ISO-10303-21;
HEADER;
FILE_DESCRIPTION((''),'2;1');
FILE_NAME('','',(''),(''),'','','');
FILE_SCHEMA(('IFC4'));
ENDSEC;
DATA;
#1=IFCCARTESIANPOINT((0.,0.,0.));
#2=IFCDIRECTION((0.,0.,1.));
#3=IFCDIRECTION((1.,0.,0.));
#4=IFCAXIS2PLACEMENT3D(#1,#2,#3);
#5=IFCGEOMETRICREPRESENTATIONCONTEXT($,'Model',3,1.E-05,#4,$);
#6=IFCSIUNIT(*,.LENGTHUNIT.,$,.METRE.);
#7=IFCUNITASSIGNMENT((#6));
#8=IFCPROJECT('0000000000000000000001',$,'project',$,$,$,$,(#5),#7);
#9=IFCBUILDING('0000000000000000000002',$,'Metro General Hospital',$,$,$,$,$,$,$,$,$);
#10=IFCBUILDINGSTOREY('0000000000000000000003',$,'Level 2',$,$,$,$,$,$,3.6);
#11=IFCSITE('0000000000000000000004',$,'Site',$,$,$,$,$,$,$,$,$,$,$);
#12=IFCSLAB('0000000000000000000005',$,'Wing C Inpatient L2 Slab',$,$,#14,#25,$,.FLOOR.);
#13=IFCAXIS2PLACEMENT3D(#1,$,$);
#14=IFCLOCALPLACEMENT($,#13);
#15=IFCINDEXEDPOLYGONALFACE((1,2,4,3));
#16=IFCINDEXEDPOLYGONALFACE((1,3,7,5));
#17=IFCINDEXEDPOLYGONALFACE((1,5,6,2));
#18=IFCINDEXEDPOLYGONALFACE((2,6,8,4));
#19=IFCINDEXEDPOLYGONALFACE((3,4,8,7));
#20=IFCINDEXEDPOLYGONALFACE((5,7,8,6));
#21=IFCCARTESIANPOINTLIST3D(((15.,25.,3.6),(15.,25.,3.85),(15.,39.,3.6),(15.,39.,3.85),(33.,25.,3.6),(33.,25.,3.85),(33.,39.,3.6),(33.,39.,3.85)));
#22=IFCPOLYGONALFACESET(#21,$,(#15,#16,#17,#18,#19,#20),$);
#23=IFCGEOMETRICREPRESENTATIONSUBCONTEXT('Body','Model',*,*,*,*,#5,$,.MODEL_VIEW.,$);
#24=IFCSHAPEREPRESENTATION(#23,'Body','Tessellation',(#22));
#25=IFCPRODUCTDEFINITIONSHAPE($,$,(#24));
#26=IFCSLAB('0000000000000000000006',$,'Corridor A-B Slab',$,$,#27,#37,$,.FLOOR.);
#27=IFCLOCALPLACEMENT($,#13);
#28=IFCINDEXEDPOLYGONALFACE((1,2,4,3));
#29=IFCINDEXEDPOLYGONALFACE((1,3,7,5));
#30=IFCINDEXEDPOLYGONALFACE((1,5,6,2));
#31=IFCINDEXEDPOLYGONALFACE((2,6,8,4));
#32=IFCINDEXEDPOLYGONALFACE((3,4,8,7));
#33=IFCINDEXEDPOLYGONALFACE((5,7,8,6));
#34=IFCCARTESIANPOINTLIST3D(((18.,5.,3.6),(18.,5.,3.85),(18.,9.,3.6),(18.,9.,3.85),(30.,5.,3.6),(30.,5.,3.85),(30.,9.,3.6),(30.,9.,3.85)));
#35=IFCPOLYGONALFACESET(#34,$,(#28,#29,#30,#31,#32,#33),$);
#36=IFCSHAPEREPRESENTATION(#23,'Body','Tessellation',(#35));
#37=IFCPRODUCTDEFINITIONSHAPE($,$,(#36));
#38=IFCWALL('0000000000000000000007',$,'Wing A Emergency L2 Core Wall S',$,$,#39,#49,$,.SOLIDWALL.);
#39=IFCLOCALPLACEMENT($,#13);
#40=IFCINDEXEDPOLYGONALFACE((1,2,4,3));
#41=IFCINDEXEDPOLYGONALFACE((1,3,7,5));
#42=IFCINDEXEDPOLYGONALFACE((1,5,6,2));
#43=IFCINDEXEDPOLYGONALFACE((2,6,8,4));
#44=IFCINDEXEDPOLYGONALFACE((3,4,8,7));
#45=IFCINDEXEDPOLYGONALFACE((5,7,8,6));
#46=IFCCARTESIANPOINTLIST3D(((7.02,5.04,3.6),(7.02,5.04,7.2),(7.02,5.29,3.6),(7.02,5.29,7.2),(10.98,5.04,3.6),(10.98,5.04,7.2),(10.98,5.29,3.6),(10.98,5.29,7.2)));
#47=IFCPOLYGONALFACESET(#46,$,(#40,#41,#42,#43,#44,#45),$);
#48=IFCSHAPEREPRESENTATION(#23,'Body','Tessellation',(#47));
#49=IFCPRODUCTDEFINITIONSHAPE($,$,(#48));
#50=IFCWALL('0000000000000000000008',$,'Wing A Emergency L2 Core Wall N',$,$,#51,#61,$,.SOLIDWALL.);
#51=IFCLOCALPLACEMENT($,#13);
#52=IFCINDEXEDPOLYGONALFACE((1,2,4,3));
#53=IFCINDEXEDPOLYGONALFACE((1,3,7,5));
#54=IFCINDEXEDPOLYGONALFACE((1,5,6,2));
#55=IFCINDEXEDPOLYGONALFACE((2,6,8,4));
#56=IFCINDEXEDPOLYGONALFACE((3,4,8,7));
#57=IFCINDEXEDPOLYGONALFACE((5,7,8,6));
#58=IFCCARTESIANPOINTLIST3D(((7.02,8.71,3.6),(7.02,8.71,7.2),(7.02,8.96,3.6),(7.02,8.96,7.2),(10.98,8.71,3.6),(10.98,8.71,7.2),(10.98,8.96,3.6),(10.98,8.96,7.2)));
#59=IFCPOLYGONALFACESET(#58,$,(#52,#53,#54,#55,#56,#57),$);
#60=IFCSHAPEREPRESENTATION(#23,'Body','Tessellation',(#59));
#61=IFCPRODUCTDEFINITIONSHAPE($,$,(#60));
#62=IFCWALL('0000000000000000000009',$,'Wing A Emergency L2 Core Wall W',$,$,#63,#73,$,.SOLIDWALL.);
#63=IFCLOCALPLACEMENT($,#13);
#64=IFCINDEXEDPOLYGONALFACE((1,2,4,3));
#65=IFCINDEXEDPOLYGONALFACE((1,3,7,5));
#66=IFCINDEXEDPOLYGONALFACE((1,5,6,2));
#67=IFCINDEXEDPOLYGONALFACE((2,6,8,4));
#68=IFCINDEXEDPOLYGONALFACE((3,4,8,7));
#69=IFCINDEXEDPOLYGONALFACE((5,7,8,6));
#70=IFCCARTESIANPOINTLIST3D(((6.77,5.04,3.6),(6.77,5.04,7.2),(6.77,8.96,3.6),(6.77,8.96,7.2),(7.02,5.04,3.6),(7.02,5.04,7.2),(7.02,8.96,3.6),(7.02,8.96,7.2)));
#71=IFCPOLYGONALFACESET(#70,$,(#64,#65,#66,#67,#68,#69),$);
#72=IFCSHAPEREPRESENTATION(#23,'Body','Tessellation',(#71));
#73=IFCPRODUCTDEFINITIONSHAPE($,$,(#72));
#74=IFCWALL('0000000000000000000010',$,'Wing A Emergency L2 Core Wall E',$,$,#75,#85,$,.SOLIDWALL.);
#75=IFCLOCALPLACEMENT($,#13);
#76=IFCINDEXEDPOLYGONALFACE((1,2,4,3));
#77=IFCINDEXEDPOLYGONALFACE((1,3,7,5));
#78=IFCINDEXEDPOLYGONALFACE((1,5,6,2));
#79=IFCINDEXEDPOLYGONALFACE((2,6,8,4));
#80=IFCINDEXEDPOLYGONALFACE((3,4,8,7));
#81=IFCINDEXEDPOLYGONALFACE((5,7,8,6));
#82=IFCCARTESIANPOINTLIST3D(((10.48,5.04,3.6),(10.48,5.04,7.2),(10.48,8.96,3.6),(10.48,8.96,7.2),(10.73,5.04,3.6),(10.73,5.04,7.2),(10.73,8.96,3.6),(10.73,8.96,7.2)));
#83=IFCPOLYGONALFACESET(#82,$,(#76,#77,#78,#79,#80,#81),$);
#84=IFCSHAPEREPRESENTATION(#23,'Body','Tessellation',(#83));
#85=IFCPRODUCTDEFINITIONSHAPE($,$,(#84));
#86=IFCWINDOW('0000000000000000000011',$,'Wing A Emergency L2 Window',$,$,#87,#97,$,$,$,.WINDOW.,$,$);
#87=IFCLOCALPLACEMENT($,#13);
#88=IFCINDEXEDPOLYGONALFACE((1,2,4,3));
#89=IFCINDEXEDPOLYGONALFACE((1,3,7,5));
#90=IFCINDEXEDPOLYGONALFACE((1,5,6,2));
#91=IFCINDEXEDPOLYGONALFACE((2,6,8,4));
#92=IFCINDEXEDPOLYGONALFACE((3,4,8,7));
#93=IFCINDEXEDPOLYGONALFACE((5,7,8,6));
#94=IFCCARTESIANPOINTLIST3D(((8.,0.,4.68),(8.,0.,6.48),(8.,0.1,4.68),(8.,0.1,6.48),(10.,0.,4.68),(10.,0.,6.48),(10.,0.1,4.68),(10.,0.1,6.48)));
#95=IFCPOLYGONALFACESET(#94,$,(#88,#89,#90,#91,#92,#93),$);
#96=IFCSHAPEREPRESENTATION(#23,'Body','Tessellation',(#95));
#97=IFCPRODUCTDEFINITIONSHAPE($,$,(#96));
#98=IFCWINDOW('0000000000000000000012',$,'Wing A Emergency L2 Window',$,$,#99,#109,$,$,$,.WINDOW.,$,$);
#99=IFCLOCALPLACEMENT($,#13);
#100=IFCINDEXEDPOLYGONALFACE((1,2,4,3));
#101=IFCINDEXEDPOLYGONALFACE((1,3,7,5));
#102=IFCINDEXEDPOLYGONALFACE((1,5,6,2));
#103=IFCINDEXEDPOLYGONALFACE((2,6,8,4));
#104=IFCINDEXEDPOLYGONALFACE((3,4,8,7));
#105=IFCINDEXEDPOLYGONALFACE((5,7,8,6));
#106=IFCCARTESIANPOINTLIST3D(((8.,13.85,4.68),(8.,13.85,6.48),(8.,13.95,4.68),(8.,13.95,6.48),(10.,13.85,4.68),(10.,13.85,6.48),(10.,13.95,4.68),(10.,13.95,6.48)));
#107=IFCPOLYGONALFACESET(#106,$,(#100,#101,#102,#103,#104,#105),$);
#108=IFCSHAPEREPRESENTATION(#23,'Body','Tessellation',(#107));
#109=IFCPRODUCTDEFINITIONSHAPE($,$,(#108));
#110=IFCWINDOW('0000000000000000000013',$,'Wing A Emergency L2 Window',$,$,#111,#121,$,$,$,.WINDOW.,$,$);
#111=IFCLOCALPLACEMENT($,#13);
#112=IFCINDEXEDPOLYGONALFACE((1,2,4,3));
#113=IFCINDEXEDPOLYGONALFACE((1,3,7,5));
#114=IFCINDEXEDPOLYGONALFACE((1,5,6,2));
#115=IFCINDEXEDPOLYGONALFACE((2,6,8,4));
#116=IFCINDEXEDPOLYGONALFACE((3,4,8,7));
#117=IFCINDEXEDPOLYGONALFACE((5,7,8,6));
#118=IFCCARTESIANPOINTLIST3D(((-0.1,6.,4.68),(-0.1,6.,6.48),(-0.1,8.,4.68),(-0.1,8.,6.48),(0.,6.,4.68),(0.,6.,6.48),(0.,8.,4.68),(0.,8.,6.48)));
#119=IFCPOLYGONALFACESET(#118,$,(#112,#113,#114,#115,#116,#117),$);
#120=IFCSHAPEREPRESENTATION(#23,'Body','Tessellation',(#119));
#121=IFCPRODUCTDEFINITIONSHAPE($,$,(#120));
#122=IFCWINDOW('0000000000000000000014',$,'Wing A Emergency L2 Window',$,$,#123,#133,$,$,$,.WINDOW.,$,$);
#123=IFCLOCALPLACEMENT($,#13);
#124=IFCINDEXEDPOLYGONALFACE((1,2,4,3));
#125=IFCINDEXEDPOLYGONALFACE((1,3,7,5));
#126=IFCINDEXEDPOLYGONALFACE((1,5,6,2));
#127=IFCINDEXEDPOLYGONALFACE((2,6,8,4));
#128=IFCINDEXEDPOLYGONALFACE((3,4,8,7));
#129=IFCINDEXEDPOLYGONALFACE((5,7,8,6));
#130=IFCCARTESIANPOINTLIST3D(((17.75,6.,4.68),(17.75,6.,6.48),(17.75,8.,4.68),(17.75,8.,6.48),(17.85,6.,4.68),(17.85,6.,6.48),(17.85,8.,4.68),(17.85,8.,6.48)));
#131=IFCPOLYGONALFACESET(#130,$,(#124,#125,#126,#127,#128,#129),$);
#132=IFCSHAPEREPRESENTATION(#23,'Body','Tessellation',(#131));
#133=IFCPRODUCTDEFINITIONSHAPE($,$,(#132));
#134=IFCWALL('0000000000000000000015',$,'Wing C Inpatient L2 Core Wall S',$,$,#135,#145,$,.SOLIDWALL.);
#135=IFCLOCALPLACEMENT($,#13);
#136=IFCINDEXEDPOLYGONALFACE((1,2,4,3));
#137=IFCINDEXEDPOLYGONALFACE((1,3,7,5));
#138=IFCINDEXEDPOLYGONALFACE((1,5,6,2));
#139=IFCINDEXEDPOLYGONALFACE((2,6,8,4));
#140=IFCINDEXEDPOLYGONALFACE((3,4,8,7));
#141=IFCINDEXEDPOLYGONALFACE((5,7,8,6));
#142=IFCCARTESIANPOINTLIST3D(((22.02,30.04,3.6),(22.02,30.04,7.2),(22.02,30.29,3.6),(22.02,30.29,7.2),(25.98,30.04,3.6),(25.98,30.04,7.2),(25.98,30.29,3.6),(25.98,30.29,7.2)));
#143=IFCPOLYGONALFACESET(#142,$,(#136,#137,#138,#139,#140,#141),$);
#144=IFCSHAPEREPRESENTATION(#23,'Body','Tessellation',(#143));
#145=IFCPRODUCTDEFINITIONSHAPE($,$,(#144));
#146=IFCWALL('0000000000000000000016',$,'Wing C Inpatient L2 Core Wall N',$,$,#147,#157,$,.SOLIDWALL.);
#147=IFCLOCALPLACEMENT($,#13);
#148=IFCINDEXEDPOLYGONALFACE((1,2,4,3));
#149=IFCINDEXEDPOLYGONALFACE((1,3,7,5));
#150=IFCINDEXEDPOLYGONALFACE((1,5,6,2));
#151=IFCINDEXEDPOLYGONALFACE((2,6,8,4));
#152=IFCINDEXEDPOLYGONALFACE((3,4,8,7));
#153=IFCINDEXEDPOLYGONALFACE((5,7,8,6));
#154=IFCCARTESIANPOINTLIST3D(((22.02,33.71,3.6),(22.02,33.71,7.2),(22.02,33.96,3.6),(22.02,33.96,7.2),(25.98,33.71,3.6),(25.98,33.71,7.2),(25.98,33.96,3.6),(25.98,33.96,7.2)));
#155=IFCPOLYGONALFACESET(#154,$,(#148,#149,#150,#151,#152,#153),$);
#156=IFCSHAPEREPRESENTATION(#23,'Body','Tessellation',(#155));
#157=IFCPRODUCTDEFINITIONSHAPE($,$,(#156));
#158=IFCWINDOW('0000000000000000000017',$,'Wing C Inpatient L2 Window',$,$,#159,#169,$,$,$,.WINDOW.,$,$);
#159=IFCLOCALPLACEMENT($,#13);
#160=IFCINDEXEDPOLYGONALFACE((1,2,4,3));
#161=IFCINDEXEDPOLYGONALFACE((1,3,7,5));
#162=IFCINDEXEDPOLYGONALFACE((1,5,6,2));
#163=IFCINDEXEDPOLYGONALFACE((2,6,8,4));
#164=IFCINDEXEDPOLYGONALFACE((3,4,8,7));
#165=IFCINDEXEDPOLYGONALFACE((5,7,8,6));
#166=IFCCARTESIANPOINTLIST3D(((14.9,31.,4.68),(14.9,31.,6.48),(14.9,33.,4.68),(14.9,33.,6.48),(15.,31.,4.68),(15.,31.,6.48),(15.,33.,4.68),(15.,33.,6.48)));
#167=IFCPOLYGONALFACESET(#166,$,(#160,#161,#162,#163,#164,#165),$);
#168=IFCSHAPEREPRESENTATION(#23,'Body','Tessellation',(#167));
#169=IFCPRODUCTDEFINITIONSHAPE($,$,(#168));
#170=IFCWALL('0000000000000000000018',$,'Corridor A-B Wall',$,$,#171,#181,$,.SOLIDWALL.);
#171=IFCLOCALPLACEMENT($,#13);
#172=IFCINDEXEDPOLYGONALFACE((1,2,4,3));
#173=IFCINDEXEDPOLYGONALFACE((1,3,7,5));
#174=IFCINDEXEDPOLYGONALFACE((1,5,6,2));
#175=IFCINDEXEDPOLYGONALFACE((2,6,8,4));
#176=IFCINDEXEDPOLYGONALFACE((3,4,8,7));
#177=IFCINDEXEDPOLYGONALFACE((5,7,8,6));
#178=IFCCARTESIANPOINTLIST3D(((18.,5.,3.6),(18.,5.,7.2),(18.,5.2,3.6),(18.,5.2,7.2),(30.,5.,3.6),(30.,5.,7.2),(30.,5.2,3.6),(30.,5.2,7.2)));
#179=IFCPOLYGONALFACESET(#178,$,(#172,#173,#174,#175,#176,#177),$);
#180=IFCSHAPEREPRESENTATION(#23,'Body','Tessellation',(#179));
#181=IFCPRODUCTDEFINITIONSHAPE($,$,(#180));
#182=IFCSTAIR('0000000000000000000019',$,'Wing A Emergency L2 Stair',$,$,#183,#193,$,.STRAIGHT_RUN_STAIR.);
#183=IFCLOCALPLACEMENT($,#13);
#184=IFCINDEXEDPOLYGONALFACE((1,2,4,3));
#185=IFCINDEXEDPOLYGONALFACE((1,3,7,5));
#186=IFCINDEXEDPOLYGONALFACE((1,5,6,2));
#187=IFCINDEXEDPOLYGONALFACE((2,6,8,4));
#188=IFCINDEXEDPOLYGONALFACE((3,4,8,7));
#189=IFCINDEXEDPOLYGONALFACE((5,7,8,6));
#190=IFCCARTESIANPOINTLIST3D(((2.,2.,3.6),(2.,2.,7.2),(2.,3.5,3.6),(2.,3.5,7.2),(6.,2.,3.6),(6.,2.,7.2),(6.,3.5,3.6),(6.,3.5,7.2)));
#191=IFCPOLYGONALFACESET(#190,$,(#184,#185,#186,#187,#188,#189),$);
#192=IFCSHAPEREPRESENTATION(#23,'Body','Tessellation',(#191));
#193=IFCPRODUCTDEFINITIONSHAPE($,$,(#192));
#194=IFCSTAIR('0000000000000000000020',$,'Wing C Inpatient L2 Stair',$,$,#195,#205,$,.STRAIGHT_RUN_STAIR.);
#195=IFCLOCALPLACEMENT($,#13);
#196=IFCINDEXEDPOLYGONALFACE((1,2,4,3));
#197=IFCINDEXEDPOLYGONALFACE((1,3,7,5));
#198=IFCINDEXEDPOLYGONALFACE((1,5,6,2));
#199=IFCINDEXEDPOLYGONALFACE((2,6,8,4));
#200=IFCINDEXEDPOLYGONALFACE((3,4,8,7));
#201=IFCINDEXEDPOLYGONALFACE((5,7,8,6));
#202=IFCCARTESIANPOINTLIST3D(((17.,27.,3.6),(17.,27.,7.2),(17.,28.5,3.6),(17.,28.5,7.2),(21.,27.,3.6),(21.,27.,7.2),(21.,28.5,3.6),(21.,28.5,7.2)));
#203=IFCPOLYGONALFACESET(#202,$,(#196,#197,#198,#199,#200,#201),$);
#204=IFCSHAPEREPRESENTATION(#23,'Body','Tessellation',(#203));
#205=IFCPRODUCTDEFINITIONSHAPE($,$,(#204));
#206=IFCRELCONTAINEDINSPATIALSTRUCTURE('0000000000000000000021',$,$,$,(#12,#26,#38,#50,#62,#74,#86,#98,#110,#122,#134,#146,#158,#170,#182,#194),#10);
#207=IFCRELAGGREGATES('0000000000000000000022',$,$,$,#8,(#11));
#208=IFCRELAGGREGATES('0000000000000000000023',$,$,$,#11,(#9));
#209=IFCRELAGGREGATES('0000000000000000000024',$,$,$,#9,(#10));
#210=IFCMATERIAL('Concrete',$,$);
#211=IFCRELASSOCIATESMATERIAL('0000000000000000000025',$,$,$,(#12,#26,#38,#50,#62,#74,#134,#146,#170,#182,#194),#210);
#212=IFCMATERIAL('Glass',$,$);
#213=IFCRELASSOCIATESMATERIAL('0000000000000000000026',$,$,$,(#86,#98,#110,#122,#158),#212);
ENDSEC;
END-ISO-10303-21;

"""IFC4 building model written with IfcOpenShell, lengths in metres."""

from ifc_helpers import new_model, si_unit, frame, origin_with_axes, place, context, subcontext, project, spatial, line, indexed_curve, outline, extrude, material, element, save


model = new_model("IFC4")

# Units and contexts
model_context = context("Model", 3, precision=1e-05, world=origin_with_axes())
body_context = subcontext(model_context, "Body", "Model", "MODEL_VIEW")
ifc_project = project(units=[si_unit("LENGTHUNIT", "METRE")], contexts=[model_context])

# Site, building, storey
site = spatial("IfcSite", under=ifc_project, Name="Site")
building = spatial("IfcBuilding", under=site, Name="Metro General Hospital")
storey = spatial("IfcBuildingStorey", under=building, Name="Level 2", Elevation=3.6)

# Slabs
ifc_material_1 = material(Name="Concrete")
for number, where, z_axis, x_axis, name in (
    (1, (15.0, 25.0, 3.6), (0.0, 0.0, 1.0), (1.0, 0.0, 0.0), "Wing C Inpatient L2 Slab"),
):
    element("IfcSlab", number, at=place(None, frame(where, z_axis=z_axis, x_axis=x_axis)), inside=storey, material=ifc_material_1, Name=name, PredefinedType="FLOOR", context=body_context, shape_type="SweptSolid", body=[
        extrude(outline(indexed_curve([(0.0, 0.0), (18.0, 0.0), (18.0, 14.0), (0.0, 14.0)], segments=[line(1, 2, 3, 4, 1)])), origin_with_axes(), (0.0, 0.0, 1.0), 0.25),
    ])
slab_placement = place(None, frame((18.0, 5.0, 3.6), z_axis=(0.0, 0.0, 1.0), x_axis=(1.0, 0.0, 0.0)))
element("IfcSlab", 2, at=slab_placement, inside=storey, material=ifc_material_1, Name="Corridor A-B Slab", PredefinedType="FLOOR", context=body_context, shape_type="SweptSolid", body=[
    extrude(outline(indexed_curve([(0.0, 0.0), (12.0, 0.0), (12.0, 4.0), (0.0, 4.0)], segments=[line(1, 2, 3, 4, 1)])), origin_with_axes(), (0.0, 0.0, 1.0), 0.25),
])

# Walls
for number, where, z_axis, x_axis, name in (
    (3, (7.02, 5.04, 3.6), (0.0, 0.0, 1.0), (1.0, 0.0, 0.0), "Wing A Emergency L2 Core Wall S"),
    (4, (7.02, 8.71, 3.6), (0.0, 0.0, 1.0), (1.0, 0.0, 0.0), "Wing A Emergency L2 Core Wall N"),
):
    element("IfcWall", number, at=place(None, frame(where, z_axis=z_axis, x_axis=x_axis)), inside=storey, material=ifc_material_1, Name=name, PredefinedType="SOLIDWALL", context=body_context, shape_type="SweptSolid", body=[
        extrude(outline(indexed_curve([(0.0, 0.0), (3.96, 0.0), (3.96, 0.25), (0.0, 0.25)], segments=[line(1, 2, 3, 4, 1)])), origin_with_axes(), (0.0, 0.0, 1.0), 3.6),
    ])
for number, where, z_axis, x_axis, name in (
    (5, (7.02, 5.04, 3.6), (0.0, 0.0, 1.0), (0.0, 1.0, 0.0), "Wing A Emergency L2 Core Wall W"),
    (6, (10.73, 5.04, 3.6), (0.0, 0.0, 1.0), (0.0, 1.0, 0.0), "Wing A Emergency L2 Core Wall E"),
):
    element("IfcWall", number, at=place(None, frame(where, z_axis=z_axis, x_axis=x_axis)), inside=storey, material=ifc_material_1, Name=name, PredefinedType="SOLIDWALL", context=body_context, shape_type="SweptSolid", body=[
        extrude(outline(indexed_curve([(0.0, 0.0), (3.92, 0.0), (3.92, 0.25), (0.0, 0.25)], segments=[line(1, 2, 3, 4, 1)])), origin_with_axes(), (0.0, 0.0, 1.0), 3.6),
    ])

# Windows
ifc_material_2 = material(Name="Glass")
for number, where, z_axis, x_axis, name in (
    (7, (8.0, 0.0, 4.68), (0.0, 0.0, 1.0), (1.0, 0.0, 0.0), "Wing A Emergency L2 Window"),
    (8, (8.0, 13.85, 4.68), (0.0, 0.0, 1.0), (1.0, 0.0, 0.0), "Wing A Emergency L2 Window"),
    (9, (0.0, 6.0, 4.68), (0.0, 0.0, 1.0), (0.0, 1.0, 0.0), "Wing A Emergency L2 Window"),
    (10, (17.85, 6.0, 4.68), (0.0, 0.0, 1.0), (0.0, 1.0, 0.0), "Wing A Emergency L2 Window"),
):
    element("IfcWindow", number, at=place(None, frame(where, z_axis=z_axis, x_axis=x_axis)), inside=storey, material=ifc_material_2, Name=name, PredefinedType="WINDOW", context=body_context, shape_type="SweptSolid", body=[
        extrude(outline(indexed_curve([(0.0, 0.0), (2.0, 0.0), (2.0, 0.1), (0.0, 0.1)], segments=[line(1, 2, 3, 4, 1)])), origin_with_axes(), (0.0, 0.0, 1.0), 1.8),
    ])

# Walls
for number, where, z_axis, x_axis, name in (
    (11, (22.02, 30.04, 3.6), (0.0, 0.0, 1.0), (1.0, 0.0, 0.0), "Wing C Inpatient L2 Core Wall S"),
    (12, (22.02, 33.71, 3.6), (0.0, 0.0, 1.0), (1.0, 0.0, 0.0), "Wing C Inpatient L2 Core Wall N"),
):
    element("IfcWall", number, at=place(None, frame(where, z_axis=z_axis, x_axis=x_axis)), inside=storey, material=ifc_material_1, Name=name, PredefinedType="SOLIDWALL", context=body_context, shape_type="SweptSolid", body=[
        extrude(outline(indexed_curve([(0.0, 0.0), (3.96, 0.0), (3.96, 0.25), (0.0, 0.25)], segments=[line(1, 2, 3, 4, 1)])), origin_with_axes(), (0.0, 0.0, 1.0), 3.6),
    ])

# Window
window_placement = place(None, frame((15.0, 31.0, 4.68), z_axis=(0.0, 0.0, 1.0), x_axis=(0.0, 1.0, 0.0)))
element("IfcWindow", 13, at=window_placement, inside=storey, material=ifc_material_2, Name="Wing C Inpatient L2 Window", PredefinedType="WINDOW", context=body_context, shape_type="SweptSolid", body=[
    extrude(outline(indexed_curve([(0.0, 0.0), (2.0, 0.0), (2.0, 0.1), (0.0, 0.1)], segments=[line(1, 2, 3, 4, 1)])), origin_with_axes(), (0.0, 0.0, 1.0), 1.8),
])

# Wall
wall_placement = place(None, frame((18.0, 5.0, 3.6), z_axis=(0.0, 0.0, 1.0), x_axis=(1.0, 0.0, 0.0)))
element("IfcWall", 14, at=wall_placement, inside=storey, material=ifc_material_1, Name="Corridor A-B Wall", PredefinedType="SOLIDWALL", context=body_context, shape_type="SweptSolid", body=[
    extrude(outline(indexed_curve([(0.0, 0.0), (12.0, 0.0), (12.0, 0.2), (0.0, 0.2)], segments=[line(1, 2, 3, 4, 1)])), origin_with_axes(), (0.0, 0.0, 1.0), 3.6),
])

# Stairs
for number, where, z_axis, x_axis, name in (
    (15, (2.0, 2.0, 3.6), (0.0, 0.0, 1.0), (1.0, 0.0, 0.0), "Wing A Emergency L2 Stair"),
    (16, (17.0, 27.0, 3.6), (0.0, 0.0, 1.0), (1.0, 0.0, 0.0), "Wing C Inpatient L2 Stair"),
):
    element("IfcStair", number, at=place(None, frame(where, z_axis=z_axis, x_axis=x_axis)), inside=storey, material=ifc_material_1, Name=name, PredefinedType="STRAIGHT_RUN_STAIR", context=body_context, shape_type="SweptSolid", body=[
        extrude(outline(indexed_curve([(0.0, 0.0), (4.0, 0.0), (4.0, 1.5), (0.0, 1.5)], segments=[line(1, 2, 3, 4, 1)])), origin_with_axes(), (0.0, 0.0, 1.0), 3.6),
    ])

save(model, "model.ifc")
